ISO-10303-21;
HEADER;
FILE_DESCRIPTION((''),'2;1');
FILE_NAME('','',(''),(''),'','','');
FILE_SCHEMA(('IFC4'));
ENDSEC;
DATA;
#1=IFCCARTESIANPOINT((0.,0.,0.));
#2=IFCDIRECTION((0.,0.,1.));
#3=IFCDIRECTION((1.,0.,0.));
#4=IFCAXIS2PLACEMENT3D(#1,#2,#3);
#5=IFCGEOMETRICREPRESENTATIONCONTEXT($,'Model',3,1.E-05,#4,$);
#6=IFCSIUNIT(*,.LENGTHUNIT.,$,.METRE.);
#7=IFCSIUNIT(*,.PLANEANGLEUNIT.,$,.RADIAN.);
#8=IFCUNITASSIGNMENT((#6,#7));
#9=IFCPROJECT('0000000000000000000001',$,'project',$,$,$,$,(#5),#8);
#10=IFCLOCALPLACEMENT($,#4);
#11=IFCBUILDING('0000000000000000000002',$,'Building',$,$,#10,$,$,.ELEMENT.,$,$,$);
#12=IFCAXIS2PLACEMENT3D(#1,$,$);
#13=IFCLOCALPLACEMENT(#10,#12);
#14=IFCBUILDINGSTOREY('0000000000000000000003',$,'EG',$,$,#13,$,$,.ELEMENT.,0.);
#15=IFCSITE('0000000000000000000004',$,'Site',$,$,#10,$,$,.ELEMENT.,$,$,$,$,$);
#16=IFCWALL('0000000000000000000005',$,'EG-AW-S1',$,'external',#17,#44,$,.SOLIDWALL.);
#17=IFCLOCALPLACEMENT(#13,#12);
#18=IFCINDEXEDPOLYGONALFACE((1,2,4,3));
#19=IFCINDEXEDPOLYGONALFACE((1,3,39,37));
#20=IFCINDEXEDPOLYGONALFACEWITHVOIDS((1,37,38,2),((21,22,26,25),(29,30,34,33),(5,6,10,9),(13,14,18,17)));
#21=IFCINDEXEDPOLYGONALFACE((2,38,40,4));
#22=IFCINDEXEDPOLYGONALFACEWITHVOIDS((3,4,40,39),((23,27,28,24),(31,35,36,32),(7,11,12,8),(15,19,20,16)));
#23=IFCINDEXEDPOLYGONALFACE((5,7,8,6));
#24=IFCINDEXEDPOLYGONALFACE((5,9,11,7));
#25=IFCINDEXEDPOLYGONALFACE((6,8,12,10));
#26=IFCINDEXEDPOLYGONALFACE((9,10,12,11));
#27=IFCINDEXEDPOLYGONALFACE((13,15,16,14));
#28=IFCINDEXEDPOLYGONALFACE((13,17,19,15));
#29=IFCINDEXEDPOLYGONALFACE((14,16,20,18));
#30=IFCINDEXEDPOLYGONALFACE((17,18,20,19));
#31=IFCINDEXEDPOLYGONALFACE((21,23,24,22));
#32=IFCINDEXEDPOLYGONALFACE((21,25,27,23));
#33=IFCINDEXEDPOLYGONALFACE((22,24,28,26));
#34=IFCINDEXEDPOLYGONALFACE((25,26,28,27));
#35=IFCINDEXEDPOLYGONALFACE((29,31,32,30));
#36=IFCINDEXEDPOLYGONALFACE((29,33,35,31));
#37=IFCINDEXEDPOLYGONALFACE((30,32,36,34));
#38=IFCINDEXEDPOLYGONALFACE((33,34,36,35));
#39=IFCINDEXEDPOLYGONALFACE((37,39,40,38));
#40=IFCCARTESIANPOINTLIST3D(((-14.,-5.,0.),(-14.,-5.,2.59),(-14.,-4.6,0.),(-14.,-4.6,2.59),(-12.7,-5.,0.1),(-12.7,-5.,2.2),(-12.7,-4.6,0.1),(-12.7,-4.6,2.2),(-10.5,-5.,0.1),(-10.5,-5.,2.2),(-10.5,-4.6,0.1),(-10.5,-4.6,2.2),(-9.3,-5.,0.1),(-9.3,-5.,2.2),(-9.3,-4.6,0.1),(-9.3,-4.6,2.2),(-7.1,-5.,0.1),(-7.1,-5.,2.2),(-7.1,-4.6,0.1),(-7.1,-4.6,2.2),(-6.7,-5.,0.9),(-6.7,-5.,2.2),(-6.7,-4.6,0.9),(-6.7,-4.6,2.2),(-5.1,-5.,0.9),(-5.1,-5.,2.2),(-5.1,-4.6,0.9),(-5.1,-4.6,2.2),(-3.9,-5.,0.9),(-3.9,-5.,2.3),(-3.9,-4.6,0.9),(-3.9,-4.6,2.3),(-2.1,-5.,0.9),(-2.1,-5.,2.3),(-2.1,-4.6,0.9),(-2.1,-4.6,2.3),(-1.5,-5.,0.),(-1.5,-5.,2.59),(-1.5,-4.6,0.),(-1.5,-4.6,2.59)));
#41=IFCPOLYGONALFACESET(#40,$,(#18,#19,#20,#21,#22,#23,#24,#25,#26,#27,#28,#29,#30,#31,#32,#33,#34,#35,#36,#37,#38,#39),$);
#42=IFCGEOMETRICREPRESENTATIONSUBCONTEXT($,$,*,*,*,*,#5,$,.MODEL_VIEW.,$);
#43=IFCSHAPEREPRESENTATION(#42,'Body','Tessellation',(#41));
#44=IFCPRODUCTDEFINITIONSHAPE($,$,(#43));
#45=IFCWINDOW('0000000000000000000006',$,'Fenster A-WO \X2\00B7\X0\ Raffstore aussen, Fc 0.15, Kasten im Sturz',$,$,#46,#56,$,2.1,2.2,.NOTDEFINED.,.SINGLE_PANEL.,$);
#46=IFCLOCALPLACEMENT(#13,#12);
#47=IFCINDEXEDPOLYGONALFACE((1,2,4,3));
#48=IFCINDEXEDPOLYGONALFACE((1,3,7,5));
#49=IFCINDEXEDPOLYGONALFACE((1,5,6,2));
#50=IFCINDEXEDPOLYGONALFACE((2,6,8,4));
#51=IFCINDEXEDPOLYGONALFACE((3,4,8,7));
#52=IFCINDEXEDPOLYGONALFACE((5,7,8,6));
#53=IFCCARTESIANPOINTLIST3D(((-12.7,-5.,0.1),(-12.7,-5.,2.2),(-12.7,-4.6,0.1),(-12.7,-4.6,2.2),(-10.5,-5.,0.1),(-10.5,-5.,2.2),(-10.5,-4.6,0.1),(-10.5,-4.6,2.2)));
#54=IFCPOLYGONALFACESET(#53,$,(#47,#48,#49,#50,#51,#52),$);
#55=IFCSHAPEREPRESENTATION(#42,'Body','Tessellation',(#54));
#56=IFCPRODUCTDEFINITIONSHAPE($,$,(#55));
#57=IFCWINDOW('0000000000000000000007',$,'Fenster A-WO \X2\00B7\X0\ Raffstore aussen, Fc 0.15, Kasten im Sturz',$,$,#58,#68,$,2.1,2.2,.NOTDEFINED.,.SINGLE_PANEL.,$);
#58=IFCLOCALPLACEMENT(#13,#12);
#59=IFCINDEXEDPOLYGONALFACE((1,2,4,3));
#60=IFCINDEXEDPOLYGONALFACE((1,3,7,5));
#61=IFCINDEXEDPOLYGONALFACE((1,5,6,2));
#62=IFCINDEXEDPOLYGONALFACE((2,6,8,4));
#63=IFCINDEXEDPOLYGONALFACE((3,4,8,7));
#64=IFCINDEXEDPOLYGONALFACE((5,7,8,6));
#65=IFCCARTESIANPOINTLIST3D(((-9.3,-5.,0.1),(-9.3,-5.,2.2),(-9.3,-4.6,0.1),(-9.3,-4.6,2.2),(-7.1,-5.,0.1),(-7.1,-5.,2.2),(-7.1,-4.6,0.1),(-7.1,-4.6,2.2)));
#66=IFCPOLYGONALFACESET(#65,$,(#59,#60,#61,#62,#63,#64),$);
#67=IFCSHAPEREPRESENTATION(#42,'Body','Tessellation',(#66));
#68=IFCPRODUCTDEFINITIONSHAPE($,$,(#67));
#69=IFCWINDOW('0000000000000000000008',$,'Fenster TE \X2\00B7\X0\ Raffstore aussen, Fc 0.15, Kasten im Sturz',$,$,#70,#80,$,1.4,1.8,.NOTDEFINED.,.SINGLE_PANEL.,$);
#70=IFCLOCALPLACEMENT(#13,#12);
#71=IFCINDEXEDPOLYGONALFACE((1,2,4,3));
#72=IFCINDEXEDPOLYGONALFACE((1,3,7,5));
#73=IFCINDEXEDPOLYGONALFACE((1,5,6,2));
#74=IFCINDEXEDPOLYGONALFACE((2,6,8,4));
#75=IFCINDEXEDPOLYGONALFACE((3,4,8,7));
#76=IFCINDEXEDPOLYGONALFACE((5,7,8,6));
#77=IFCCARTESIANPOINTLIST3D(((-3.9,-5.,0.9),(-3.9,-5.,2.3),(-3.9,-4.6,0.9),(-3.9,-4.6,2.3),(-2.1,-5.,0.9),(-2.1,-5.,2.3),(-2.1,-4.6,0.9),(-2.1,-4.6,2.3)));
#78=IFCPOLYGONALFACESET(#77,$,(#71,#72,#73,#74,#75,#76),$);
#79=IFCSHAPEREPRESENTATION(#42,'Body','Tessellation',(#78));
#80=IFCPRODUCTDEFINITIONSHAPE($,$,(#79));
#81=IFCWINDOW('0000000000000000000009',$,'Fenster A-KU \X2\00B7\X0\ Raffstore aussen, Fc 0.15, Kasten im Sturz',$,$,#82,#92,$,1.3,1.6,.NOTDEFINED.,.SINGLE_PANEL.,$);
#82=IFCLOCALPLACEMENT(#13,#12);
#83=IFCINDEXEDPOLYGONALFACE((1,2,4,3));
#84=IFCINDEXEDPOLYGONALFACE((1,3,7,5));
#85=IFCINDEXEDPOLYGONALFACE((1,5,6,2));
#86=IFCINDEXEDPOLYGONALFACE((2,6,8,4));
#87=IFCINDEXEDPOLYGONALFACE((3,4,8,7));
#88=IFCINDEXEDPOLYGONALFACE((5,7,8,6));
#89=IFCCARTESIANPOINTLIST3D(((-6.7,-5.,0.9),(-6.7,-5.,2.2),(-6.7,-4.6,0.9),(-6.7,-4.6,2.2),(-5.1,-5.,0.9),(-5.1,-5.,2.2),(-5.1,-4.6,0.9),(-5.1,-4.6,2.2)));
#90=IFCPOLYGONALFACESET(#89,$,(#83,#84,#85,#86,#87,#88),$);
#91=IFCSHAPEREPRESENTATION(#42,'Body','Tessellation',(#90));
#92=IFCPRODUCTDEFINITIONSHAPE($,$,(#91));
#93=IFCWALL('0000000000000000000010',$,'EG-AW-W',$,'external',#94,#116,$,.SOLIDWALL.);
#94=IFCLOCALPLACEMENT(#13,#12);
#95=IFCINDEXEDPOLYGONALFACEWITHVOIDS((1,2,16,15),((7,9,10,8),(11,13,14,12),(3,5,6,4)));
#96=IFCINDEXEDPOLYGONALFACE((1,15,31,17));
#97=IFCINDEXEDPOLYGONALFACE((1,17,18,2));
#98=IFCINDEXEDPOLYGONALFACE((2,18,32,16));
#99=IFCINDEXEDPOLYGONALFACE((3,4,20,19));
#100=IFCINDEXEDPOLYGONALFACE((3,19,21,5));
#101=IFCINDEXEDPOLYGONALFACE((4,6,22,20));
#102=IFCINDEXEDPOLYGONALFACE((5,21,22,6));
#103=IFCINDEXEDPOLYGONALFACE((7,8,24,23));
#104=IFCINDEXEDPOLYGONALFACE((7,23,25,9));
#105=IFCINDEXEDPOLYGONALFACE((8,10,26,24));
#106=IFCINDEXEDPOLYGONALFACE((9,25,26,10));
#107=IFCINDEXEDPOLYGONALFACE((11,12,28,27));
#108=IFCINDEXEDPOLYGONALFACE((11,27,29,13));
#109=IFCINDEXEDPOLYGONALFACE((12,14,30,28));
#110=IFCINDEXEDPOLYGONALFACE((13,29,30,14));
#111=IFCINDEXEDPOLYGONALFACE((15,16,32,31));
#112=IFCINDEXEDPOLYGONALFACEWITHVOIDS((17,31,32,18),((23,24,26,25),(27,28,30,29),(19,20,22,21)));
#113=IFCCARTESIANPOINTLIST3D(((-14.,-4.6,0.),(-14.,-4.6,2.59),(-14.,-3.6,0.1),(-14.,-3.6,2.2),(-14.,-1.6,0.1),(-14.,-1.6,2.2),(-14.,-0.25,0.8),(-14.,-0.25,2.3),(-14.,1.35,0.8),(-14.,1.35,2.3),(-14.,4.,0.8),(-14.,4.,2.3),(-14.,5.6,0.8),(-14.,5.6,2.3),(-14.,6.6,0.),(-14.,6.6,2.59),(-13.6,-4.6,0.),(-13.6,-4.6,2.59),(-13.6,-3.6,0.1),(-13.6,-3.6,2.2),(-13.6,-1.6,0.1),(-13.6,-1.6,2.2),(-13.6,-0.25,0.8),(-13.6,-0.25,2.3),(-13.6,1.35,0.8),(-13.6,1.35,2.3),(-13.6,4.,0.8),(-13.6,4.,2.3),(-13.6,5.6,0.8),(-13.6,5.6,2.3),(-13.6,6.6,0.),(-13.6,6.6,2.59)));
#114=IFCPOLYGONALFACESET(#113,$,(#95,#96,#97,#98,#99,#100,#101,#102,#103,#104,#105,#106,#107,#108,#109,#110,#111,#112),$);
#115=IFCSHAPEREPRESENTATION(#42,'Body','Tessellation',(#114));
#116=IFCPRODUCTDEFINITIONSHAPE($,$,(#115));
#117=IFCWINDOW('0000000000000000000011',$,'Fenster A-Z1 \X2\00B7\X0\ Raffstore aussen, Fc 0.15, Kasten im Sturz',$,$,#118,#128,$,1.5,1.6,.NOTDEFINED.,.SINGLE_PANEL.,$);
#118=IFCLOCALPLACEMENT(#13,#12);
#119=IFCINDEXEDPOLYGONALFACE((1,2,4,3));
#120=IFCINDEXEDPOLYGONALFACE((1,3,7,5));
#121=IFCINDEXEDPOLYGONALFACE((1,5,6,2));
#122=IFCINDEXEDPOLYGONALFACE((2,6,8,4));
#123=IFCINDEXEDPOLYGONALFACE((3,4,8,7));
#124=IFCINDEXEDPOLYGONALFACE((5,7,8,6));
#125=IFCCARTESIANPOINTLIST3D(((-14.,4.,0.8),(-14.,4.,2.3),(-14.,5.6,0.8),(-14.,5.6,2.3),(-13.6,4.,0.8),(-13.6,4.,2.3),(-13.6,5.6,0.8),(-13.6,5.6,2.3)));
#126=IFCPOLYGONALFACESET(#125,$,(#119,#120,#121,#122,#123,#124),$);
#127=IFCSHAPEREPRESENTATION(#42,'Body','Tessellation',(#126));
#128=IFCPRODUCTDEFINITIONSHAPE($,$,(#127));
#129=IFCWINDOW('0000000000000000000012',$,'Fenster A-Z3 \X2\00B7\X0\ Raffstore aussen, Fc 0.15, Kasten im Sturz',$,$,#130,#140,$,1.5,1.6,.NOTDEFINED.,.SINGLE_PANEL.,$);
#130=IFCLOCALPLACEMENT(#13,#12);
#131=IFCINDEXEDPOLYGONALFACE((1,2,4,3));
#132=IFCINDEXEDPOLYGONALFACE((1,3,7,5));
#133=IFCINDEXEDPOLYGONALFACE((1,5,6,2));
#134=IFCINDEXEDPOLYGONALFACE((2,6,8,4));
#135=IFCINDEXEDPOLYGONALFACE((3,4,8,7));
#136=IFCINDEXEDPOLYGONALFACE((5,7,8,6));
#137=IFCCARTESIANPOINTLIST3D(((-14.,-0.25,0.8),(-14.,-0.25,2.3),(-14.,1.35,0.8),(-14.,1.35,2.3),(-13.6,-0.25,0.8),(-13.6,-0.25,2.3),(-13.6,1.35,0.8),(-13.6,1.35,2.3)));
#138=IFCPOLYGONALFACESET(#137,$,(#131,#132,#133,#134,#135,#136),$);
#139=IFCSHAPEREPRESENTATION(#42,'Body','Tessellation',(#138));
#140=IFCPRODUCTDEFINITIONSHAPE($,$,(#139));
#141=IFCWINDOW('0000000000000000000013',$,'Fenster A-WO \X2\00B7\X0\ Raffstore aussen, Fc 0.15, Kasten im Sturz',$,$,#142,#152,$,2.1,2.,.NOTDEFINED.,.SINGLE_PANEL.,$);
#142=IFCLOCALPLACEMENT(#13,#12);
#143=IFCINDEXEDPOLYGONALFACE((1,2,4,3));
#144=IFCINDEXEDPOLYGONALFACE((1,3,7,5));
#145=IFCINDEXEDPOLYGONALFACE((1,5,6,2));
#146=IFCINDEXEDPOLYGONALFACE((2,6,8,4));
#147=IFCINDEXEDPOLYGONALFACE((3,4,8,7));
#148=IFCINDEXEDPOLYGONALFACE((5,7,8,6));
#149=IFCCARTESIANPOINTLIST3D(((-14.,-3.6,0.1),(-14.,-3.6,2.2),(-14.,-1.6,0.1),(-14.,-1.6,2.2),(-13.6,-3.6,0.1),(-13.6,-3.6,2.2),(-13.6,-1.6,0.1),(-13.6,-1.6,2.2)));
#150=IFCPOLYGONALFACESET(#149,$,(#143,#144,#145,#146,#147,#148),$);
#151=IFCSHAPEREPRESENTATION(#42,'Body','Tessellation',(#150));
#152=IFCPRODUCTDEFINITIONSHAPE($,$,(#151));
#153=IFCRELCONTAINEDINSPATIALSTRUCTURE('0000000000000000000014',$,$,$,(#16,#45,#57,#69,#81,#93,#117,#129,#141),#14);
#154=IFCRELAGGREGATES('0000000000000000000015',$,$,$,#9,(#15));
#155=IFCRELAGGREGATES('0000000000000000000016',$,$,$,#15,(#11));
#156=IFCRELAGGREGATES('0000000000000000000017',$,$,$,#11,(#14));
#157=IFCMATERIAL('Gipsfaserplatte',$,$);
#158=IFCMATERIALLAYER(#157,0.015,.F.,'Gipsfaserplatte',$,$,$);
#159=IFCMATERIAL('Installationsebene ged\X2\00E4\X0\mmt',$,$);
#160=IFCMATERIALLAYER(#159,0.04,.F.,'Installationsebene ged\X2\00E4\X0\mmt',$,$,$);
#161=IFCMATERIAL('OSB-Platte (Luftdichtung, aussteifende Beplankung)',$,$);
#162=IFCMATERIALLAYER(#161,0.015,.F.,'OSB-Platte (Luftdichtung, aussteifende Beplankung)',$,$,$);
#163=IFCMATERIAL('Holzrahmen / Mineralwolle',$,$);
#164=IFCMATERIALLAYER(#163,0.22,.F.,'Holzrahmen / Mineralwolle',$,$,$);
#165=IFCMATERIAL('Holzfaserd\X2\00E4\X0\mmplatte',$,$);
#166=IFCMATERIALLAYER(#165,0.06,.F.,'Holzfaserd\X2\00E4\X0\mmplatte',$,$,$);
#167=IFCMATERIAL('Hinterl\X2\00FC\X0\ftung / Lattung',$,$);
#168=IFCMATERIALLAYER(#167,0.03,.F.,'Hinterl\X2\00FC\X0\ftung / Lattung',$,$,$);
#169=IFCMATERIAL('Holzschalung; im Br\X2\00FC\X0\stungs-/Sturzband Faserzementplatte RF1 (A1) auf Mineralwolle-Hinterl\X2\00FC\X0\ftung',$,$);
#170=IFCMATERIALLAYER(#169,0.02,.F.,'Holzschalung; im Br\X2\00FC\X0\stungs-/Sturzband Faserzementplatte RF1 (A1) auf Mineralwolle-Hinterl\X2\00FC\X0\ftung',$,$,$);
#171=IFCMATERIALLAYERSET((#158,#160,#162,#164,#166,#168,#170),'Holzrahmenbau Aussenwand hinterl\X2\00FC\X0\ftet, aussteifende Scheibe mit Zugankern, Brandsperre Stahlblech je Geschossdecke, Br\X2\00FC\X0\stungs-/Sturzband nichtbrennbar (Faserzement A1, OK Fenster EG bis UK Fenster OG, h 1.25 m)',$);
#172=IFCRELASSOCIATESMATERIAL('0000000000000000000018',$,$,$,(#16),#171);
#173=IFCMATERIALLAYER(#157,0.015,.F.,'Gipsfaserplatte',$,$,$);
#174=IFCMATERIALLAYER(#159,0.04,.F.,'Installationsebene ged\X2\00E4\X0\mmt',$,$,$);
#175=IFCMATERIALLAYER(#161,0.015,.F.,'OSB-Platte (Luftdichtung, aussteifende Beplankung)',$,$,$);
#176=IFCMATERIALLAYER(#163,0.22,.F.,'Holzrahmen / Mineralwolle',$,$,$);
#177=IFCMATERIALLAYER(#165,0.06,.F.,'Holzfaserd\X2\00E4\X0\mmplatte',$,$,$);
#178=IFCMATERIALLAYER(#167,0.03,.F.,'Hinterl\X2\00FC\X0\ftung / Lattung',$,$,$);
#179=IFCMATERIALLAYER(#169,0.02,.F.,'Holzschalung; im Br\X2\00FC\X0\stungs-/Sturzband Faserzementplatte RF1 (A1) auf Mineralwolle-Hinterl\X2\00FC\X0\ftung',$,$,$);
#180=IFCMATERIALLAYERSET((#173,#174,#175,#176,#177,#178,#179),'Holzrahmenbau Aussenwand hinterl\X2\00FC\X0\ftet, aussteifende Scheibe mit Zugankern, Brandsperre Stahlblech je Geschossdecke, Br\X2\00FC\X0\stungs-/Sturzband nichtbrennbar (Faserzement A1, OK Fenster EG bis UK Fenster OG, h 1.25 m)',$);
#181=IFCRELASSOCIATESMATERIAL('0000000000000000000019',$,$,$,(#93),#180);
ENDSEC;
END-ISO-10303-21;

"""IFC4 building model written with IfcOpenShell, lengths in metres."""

from ifc_helpers import new_model, si_unit, frame, frame_2d, origin, origin_with_axes, place, context, subcontext, project, spatial, rectangle, extrude, material, layer, layer_set, element, fill, save


model = new_model("IFC4")

# Units and contexts
model_context = context("Model", 3, precision=1e-05, world=origin_with_axes())
sub_context = subcontext(model_context, None, None, "MODEL_VIEW")
ifc_project = project(units=[si_unit("LENGTHUNIT", "METRE"), si_unit("PLANEANGLEUNIT", "RADIAN")], contexts=[model_context])

# Site, building, storey
placement = place(None, origin_with_axes())
site = spatial("IfcSite", under=ifc_project, at=placement, Name="Site", CompositionType="ELEMENT")
building = spatial("IfcBuilding", under=site, at=placement, Name="Building", CompositionType="ELEMENT")
storey_placement = place(placement, origin())
storey = spatial("IfcBuildingStorey", under=building, at=storey_placement, Name="EG", CompositionType="ELEMENT", Elevation=0.0)

# Walls, openings, windows
ifc_material_1 = material(Name="Gipsfaserplatte")
ifc_layer_1 = layer(ifc_material_1, 0.015, ventilated=False, Name="Gipsfaserplatte")
ifc_material_2 = material(Name="Installationsebene gedämmt")
ifc_layer_2 = layer(ifc_material_2, 0.04, ventilated=False, Name="Installationsebene gedämmt")
ifc_material_3 = material(Name="OSB-Platte (Luftdichtung, aussteifende Beplankung)")
ifc_layer_3 = layer(ifc_material_3, 0.015, ventilated=False, Name="OSB-Platte (Luftdichtung, aussteifende Beplankung)")
ifc_material_4 = material(Name="Holzrahmen / Mineralwolle")
ifc_layer_4 = layer(ifc_material_4, 0.22, ventilated=False, Name="Holzrahmen / Mineralwolle")
ifc_material_5 = material(Name="Holzfaserdämmplatte")
ifc_layer_5 = layer(ifc_material_5, 0.06, ventilated=False, Name="Holzfaserdämmplatte")
ifc_material_6 = material(Name="Hinterlüftung / Lattung")
ifc_layer_6 = layer(ifc_material_6, 0.03, ventilated=False, Name="Hinterlüftung / Lattung")
ifc_material_7 = material(Name="Holzschalung; im Brüstungs-/Sturzband Faserzementplatte RF1 (A1) auf Mineralwolle-Hinterlüftung")
ifc_layer_7 = layer(ifc_material_7, 0.02, ventilated=False, Name="Holzschalung; im Brüstungs-/Sturzband Faserzementplatte RF1 (A1) auf Mineralwolle-Hinterlüftung")
ifc_layer_set_1 = layer_set([ifc_layer_1, ifc_layer_2, ifc_layer_3, ifc_layer_4, ifc_layer_5, ifc_layer_6, ifc_layer_7], Name="Holzrahmenbau Aussenwand hinterlüftet, aussteifende Scheibe mit Zugankern, Brandsperre Stahlblech je Geschossdecke, Brüstungs-/Sturzband nichtbrennbar (Faserzement A1, OK Fenster EG bis UK Fenster OG, h 1.25 m)")
wall_1_placement = place(storey_placement, frame((-14.0, -4.8, 0.0), z_axis=(0.0, 0.0, 1.0), x_axis=(1.0, 0.0, 0.0)))
wall_1 = element("IfcWall", 1, at=wall_1_placement, inside=storey, material=ifc_layer_set_1, Name="EG-AW-S1", ObjectType="external", PredefinedType="SOLIDWALL", context=sub_context, shape_type="SweptSolid", body=[
    extrude(rectangle(XDim=12.5, YDim=0.4, at=frame_2d((6.25, 0.0))), origin(), (0.0, 0.0, 1.0), 2.59),
])
opening_1_placement = place(wall_1_placement, frame((2.4, 0.25, 0.1), z_axis=(0.0, -1.0, 0.0), x_axis=(1.0, 0.0, 0.0)))
opening_1 = element("IfcOpeningElement", 2, at=opening_1_placement, cuts=wall_1, PredefinedType="OPENING", context=sub_context, shape_type="SweptSolid", body=[
    extrude(rectangle(XDim=2.2, YDim=2.1, at=frame_2d((0.0, 1.05))), origin(), (0.0, 0.0, 1.0), 0.5),
])
opening_2_placement = place(wall_1_placement, frame((5.8, 0.25, 0.1), z_axis=(0.0, -1.0, 0.0), x_axis=(1.0, 0.0, 0.0)))
opening_2 = element("IfcOpeningElement", 3, at=opening_2_placement, cuts=wall_1, PredefinedType="OPENING", context=sub_context, shape_type="SweptSolid", body=[
    extrude(rectangle(XDim=2.2, YDim=2.1, at=frame_2d((0.0, 1.05))), origin(), (0.0, 0.0, 1.0), 0.5),
])
opening_3_placement = place(wall_1_placement, frame((11.0, 0.25, 0.9), z_axis=(0.0, -1.0, 0.0), x_axis=(1.0, 0.0, 0.0)))
opening_3 = element("IfcOpeningElement", 4, at=opening_3_placement, cuts=wall_1, PredefinedType="OPENING", context=sub_context, shape_type="SweptSolid", body=[
    extrude(rectangle(XDim=1.8, YDim=1.4, at=frame_2d((0.0, 0.7))), origin(), (0.0, 0.0, 1.0), 0.5),
])
opening_4_placement = place(wall_1_placement, frame((8.1, 0.25, 0.9), z_axis=(0.0, -1.0, 0.0), x_axis=(1.0, 0.0, 0.0)))
opening_4 = element("IfcOpeningElement", 5, at=opening_4_placement, cuts=wall_1, PredefinedType="OPENING", context=sub_context, shape_type="SweptSolid", body=[
    extrude(rectangle(XDim=1.6, YDim=1.3, at=frame_2d((0.0, 0.65))), origin(), (0.0, 0.0, 1.0), 0.5),
])
window_1_placement = place(wall_1_placement, frame((2.4, 0.2, 0.1), z_axis=(0.0, -1.0, 0.0), x_axis=(1.0, 0.0, 0.0)))
window_1 = element("IfcWindow", 6, at=window_1_placement, inside=storey, Name="Fenster A-WO · Raffstore aussen, Fc 0.15, Kasten im Sturz", OverallHeight=2.1, OverallWidth=2.2, PartitioningType="SINGLE_PANEL", PredefinedType="NOTDEFINED", context=sub_context, shape_type="SweptSolid", body=[
    extrude(rectangle(XDim=2.2, YDim=2.1, at=frame_2d((0.0, 1.05))), origin(), (0.0, 0.0, 1.0), 0.4),
])
fill(opening_1, window_1)
window_2_placement = place(wall_1_placement, frame((5.8, 0.2, 0.1), z_axis=(0.0, -1.0, 0.0), x_axis=(1.0, 0.0, 0.0)))
window_2 = element("IfcWindow", 7, at=window_2_placement, inside=storey, Name="Fenster A-WO · Raffstore aussen, Fc 0.15, Kasten im Sturz", OverallHeight=2.1, OverallWidth=2.2, PartitioningType="SINGLE_PANEL", PredefinedType="NOTDEFINED", context=sub_context, shape_type="SweptSolid", body=[
    extrude(rectangle(XDim=2.2, YDim=2.1, at=frame_2d((0.0, 1.05))), origin(), (0.0, 0.0, 1.0), 0.4),
])
fill(opening_2, window_2)
window_3_placement = place(wall_1_placement, frame((11.0, 0.2, 0.9), z_axis=(0.0, -1.0, 0.0), x_axis=(1.0, 0.0, 0.0)))
window_3 = element("IfcWindow", 8, at=window_3_placement, inside=storey, Name="Fenster TE · Raffstore aussen, Fc 0.15, Kasten im Sturz", OverallHeight=1.4, OverallWidth=1.8, PartitioningType="SINGLE_PANEL", PredefinedType="NOTDEFINED", context=sub_context, shape_type="SweptSolid", body=[
    extrude(rectangle(XDim=1.8, YDim=1.4, at=frame_2d((0.0, 0.7))), origin(), (0.0, 0.0, 1.0), 0.4),
])
fill(opening_3, window_3)
window_4_placement = place(wall_1_placement, frame((8.1, 0.2, 0.9), z_axis=(0.0, -1.0, 0.0), x_axis=(1.0, 0.0, 0.0)))
window_4 = element("IfcWindow", 9, at=window_4_placement, inside=storey, Name="Fenster A-KU · Raffstore aussen, Fc 0.15, Kasten im Sturz", OverallHeight=1.3, OverallWidth=1.6, PartitioningType="SINGLE_PANEL", PredefinedType="NOTDEFINED", context=sub_context, shape_type="SweptSolid", body=[
    extrude(rectangle(XDim=1.6, YDim=1.3, at=frame_2d((0.0, 0.65))), origin(), (0.0, 0.0, 1.0), 0.4),
])
fill(opening_4, window_4)
ifc_layer_8 = layer(ifc_material_1, 0.015, ventilated=False, Name="Gipsfaserplatte")
ifc_layer_9 = layer(ifc_material_2, 0.04, ventilated=False, Name="Installationsebene gedämmt")
ifc_layer_10 = layer(ifc_material_3, 0.015, ventilated=False, Name="OSB-Platte (Luftdichtung, aussteifende Beplankung)")
ifc_layer_11 = layer(ifc_material_4, 0.22, ventilated=False, Name="Holzrahmen / Mineralwolle")
ifc_layer_12 = layer(ifc_material_5, 0.06, ventilated=False, Name="Holzfaserdämmplatte")
ifc_layer_13 = layer(ifc_material_6, 0.03, ventilated=False, Name="Hinterlüftung / Lattung")
ifc_layer_14 = layer(ifc_material_7, 0.02, ventilated=False, Name="Holzschalung; im Brüstungs-/Sturzband Faserzementplatte RF1 (A1) auf Mineralwolle-Hinterlüftung")
ifc_layer_set_2 = layer_set([ifc_layer_8, ifc_layer_9, ifc_layer_10, ifc_layer_11, ifc_layer_12, ifc_layer_13, ifc_layer_14], Name="Holzrahmenbau Aussenwand hinterlüftet, aussteifende Scheibe mit Zugankern, Brandsperre Stahlblech je Geschossdecke, Brüstungs-/Sturzband nichtbrennbar (Faserzement A1, OK Fenster EG bis UK Fenster OG, h 1.25 m)")
wall_2_placement = place(storey_placement, frame((-13.8, -4.6, 0.0), z_axis=(0.0, 0.0, 1.0), x_axis=(0.0, 1.0, 0.0)))
wall_2 = element("IfcWall", 10, at=wall_2_placement, inside=storey, material=ifc_layer_set_2, Name="EG-AW-W", ObjectType="external", PredefinedType="SOLIDWALL", context=sub_context, shape_type="SweptSolid", body=[
    extrude(rectangle(XDim=11.2, YDim=0.4, at=frame_2d((5.6, 0.0))), origin(), (0.0, 0.0, 1.0), 2.59),
])
opening_5_placement = place(wall_2_placement, frame((9.4, 0.25, 0.8), z_axis=(0.0, -1.0, 0.0), x_axis=(1.0, 0.0, 0.0)))
opening_5 = element("IfcOpeningElement", 11, at=opening_5_placement, cuts=wall_2, PredefinedType="OPENING", context=sub_context, shape_type="SweptSolid", body=[
    extrude(rectangle(XDim=1.6, YDim=1.5, at=frame_2d((0.0, 0.75))), origin(), (0.0, 0.0, 1.0), 0.5),
])
opening_6_placement = place(wall_2_placement, frame((5.15, 0.25, 0.8), z_axis=(0.0, -1.0, 0.0), x_axis=(1.0, 0.0, 0.0)))
opening_6 = element("IfcOpeningElement", 12, at=opening_6_placement, cuts=wall_2, PredefinedType="OPENING", context=sub_context, shape_type="SweptSolid", body=[
    extrude(rectangle(XDim=1.6, YDim=1.5, at=frame_2d((0.0, 0.75))), origin(), (0.0, 0.0, 1.0), 0.5),
])
opening_7_placement = place(wall_2_placement, frame((2.0, 0.25, 0.1), z_axis=(0.0, -1.0, 0.0), x_axis=(1.0, 0.0, 0.0)))
opening_7 = element("IfcOpeningElement", 13, at=opening_7_placement, cuts=wall_2, PredefinedType="OPENING", context=sub_context, shape_type="SweptSolid", body=[
    extrude(rectangle(XDim=2.0, YDim=2.1, at=frame_2d((0.0, 1.05))), origin(), (0.0, 0.0, 1.0), 0.5),
])
window_5_placement = place(wall_2_placement, frame((9.4, 0.2, 0.8), z_axis=(0.0, -1.0, 0.0), x_axis=(1.0, 0.0, 0.0)))
window_5 = element("IfcWindow", 14, at=window_5_placement, inside=storey, Name="Fenster A-Z1 · Raffstore aussen, Fc 0.15, Kasten im Sturz", OverallHeight=1.5, OverallWidth=1.6, PartitioningType="SINGLE_PANEL", PredefinedType="NOTDEFINED", context=sub_context, shape_type="SweptSolid", body=[
    extrude(rectangle(XDim=1.6, YDim=1.5, at=frame_2d((0.0, 0.75))), origin(), (0.0, 0.0, 1.0), 0.4),
])
fill(opening_5, window_5)
window_6_placement = place(wall_2_placement, frame((5.15, 0.2, 0.8), z_axis=(0.0, -1.0, 0.0), x_axis=(1.0, 0.0, 0.0)))
window_6 = element("IfcWindow", 15, at=window_6_placement, inside=storey, Name="Fenster A-Z3 · Raffstore aussen, Fc 0.15, Kasten im Sturz", OverallHeight=1.5, OverallWidth=1.6, PartitioningType="SINGLE_PANEL", PredefinedType="NOTDEFINED", context=sub_context, shape_type="SweptSolid", body=[
    extrude(rectangle(XDim=1.6, YDim=1.5, at=frame_2d((0.0, 0.75))), origin(), (0.0, 0.0, 1.0), 0.4),
])
fill(opening_6, window_6)
window_7_placement = place(wall_2_placement, frame((2.0, 0.2, 0.1), z_axis=(0.0, -1.0, 0.0), x_axis=(1.0, 0.0, 0.0)))
window_7 = element("IfcWindow", 16, at=window_7_placement, inside=storey, Name="Fenster A-WO · Raffstore aussen, Fc 0.15, Kasten im Sturz", OverallHeight=2.1, OverallWidth=2.0, PartitioningType="SINGLE_PANEL", PredefinedType="NOTDEFINED", context=sub_context, shape_type="SweptSolid", body=[
    extrude(rectangle(XDim=2.0, YDim=2.1, at=frame_2d((0.0, 1.05))), origin(), (0.0, 0.0, 1.0), 0.4),
])
fill(opening_7, window_7)

save(model, "model.ifc")
